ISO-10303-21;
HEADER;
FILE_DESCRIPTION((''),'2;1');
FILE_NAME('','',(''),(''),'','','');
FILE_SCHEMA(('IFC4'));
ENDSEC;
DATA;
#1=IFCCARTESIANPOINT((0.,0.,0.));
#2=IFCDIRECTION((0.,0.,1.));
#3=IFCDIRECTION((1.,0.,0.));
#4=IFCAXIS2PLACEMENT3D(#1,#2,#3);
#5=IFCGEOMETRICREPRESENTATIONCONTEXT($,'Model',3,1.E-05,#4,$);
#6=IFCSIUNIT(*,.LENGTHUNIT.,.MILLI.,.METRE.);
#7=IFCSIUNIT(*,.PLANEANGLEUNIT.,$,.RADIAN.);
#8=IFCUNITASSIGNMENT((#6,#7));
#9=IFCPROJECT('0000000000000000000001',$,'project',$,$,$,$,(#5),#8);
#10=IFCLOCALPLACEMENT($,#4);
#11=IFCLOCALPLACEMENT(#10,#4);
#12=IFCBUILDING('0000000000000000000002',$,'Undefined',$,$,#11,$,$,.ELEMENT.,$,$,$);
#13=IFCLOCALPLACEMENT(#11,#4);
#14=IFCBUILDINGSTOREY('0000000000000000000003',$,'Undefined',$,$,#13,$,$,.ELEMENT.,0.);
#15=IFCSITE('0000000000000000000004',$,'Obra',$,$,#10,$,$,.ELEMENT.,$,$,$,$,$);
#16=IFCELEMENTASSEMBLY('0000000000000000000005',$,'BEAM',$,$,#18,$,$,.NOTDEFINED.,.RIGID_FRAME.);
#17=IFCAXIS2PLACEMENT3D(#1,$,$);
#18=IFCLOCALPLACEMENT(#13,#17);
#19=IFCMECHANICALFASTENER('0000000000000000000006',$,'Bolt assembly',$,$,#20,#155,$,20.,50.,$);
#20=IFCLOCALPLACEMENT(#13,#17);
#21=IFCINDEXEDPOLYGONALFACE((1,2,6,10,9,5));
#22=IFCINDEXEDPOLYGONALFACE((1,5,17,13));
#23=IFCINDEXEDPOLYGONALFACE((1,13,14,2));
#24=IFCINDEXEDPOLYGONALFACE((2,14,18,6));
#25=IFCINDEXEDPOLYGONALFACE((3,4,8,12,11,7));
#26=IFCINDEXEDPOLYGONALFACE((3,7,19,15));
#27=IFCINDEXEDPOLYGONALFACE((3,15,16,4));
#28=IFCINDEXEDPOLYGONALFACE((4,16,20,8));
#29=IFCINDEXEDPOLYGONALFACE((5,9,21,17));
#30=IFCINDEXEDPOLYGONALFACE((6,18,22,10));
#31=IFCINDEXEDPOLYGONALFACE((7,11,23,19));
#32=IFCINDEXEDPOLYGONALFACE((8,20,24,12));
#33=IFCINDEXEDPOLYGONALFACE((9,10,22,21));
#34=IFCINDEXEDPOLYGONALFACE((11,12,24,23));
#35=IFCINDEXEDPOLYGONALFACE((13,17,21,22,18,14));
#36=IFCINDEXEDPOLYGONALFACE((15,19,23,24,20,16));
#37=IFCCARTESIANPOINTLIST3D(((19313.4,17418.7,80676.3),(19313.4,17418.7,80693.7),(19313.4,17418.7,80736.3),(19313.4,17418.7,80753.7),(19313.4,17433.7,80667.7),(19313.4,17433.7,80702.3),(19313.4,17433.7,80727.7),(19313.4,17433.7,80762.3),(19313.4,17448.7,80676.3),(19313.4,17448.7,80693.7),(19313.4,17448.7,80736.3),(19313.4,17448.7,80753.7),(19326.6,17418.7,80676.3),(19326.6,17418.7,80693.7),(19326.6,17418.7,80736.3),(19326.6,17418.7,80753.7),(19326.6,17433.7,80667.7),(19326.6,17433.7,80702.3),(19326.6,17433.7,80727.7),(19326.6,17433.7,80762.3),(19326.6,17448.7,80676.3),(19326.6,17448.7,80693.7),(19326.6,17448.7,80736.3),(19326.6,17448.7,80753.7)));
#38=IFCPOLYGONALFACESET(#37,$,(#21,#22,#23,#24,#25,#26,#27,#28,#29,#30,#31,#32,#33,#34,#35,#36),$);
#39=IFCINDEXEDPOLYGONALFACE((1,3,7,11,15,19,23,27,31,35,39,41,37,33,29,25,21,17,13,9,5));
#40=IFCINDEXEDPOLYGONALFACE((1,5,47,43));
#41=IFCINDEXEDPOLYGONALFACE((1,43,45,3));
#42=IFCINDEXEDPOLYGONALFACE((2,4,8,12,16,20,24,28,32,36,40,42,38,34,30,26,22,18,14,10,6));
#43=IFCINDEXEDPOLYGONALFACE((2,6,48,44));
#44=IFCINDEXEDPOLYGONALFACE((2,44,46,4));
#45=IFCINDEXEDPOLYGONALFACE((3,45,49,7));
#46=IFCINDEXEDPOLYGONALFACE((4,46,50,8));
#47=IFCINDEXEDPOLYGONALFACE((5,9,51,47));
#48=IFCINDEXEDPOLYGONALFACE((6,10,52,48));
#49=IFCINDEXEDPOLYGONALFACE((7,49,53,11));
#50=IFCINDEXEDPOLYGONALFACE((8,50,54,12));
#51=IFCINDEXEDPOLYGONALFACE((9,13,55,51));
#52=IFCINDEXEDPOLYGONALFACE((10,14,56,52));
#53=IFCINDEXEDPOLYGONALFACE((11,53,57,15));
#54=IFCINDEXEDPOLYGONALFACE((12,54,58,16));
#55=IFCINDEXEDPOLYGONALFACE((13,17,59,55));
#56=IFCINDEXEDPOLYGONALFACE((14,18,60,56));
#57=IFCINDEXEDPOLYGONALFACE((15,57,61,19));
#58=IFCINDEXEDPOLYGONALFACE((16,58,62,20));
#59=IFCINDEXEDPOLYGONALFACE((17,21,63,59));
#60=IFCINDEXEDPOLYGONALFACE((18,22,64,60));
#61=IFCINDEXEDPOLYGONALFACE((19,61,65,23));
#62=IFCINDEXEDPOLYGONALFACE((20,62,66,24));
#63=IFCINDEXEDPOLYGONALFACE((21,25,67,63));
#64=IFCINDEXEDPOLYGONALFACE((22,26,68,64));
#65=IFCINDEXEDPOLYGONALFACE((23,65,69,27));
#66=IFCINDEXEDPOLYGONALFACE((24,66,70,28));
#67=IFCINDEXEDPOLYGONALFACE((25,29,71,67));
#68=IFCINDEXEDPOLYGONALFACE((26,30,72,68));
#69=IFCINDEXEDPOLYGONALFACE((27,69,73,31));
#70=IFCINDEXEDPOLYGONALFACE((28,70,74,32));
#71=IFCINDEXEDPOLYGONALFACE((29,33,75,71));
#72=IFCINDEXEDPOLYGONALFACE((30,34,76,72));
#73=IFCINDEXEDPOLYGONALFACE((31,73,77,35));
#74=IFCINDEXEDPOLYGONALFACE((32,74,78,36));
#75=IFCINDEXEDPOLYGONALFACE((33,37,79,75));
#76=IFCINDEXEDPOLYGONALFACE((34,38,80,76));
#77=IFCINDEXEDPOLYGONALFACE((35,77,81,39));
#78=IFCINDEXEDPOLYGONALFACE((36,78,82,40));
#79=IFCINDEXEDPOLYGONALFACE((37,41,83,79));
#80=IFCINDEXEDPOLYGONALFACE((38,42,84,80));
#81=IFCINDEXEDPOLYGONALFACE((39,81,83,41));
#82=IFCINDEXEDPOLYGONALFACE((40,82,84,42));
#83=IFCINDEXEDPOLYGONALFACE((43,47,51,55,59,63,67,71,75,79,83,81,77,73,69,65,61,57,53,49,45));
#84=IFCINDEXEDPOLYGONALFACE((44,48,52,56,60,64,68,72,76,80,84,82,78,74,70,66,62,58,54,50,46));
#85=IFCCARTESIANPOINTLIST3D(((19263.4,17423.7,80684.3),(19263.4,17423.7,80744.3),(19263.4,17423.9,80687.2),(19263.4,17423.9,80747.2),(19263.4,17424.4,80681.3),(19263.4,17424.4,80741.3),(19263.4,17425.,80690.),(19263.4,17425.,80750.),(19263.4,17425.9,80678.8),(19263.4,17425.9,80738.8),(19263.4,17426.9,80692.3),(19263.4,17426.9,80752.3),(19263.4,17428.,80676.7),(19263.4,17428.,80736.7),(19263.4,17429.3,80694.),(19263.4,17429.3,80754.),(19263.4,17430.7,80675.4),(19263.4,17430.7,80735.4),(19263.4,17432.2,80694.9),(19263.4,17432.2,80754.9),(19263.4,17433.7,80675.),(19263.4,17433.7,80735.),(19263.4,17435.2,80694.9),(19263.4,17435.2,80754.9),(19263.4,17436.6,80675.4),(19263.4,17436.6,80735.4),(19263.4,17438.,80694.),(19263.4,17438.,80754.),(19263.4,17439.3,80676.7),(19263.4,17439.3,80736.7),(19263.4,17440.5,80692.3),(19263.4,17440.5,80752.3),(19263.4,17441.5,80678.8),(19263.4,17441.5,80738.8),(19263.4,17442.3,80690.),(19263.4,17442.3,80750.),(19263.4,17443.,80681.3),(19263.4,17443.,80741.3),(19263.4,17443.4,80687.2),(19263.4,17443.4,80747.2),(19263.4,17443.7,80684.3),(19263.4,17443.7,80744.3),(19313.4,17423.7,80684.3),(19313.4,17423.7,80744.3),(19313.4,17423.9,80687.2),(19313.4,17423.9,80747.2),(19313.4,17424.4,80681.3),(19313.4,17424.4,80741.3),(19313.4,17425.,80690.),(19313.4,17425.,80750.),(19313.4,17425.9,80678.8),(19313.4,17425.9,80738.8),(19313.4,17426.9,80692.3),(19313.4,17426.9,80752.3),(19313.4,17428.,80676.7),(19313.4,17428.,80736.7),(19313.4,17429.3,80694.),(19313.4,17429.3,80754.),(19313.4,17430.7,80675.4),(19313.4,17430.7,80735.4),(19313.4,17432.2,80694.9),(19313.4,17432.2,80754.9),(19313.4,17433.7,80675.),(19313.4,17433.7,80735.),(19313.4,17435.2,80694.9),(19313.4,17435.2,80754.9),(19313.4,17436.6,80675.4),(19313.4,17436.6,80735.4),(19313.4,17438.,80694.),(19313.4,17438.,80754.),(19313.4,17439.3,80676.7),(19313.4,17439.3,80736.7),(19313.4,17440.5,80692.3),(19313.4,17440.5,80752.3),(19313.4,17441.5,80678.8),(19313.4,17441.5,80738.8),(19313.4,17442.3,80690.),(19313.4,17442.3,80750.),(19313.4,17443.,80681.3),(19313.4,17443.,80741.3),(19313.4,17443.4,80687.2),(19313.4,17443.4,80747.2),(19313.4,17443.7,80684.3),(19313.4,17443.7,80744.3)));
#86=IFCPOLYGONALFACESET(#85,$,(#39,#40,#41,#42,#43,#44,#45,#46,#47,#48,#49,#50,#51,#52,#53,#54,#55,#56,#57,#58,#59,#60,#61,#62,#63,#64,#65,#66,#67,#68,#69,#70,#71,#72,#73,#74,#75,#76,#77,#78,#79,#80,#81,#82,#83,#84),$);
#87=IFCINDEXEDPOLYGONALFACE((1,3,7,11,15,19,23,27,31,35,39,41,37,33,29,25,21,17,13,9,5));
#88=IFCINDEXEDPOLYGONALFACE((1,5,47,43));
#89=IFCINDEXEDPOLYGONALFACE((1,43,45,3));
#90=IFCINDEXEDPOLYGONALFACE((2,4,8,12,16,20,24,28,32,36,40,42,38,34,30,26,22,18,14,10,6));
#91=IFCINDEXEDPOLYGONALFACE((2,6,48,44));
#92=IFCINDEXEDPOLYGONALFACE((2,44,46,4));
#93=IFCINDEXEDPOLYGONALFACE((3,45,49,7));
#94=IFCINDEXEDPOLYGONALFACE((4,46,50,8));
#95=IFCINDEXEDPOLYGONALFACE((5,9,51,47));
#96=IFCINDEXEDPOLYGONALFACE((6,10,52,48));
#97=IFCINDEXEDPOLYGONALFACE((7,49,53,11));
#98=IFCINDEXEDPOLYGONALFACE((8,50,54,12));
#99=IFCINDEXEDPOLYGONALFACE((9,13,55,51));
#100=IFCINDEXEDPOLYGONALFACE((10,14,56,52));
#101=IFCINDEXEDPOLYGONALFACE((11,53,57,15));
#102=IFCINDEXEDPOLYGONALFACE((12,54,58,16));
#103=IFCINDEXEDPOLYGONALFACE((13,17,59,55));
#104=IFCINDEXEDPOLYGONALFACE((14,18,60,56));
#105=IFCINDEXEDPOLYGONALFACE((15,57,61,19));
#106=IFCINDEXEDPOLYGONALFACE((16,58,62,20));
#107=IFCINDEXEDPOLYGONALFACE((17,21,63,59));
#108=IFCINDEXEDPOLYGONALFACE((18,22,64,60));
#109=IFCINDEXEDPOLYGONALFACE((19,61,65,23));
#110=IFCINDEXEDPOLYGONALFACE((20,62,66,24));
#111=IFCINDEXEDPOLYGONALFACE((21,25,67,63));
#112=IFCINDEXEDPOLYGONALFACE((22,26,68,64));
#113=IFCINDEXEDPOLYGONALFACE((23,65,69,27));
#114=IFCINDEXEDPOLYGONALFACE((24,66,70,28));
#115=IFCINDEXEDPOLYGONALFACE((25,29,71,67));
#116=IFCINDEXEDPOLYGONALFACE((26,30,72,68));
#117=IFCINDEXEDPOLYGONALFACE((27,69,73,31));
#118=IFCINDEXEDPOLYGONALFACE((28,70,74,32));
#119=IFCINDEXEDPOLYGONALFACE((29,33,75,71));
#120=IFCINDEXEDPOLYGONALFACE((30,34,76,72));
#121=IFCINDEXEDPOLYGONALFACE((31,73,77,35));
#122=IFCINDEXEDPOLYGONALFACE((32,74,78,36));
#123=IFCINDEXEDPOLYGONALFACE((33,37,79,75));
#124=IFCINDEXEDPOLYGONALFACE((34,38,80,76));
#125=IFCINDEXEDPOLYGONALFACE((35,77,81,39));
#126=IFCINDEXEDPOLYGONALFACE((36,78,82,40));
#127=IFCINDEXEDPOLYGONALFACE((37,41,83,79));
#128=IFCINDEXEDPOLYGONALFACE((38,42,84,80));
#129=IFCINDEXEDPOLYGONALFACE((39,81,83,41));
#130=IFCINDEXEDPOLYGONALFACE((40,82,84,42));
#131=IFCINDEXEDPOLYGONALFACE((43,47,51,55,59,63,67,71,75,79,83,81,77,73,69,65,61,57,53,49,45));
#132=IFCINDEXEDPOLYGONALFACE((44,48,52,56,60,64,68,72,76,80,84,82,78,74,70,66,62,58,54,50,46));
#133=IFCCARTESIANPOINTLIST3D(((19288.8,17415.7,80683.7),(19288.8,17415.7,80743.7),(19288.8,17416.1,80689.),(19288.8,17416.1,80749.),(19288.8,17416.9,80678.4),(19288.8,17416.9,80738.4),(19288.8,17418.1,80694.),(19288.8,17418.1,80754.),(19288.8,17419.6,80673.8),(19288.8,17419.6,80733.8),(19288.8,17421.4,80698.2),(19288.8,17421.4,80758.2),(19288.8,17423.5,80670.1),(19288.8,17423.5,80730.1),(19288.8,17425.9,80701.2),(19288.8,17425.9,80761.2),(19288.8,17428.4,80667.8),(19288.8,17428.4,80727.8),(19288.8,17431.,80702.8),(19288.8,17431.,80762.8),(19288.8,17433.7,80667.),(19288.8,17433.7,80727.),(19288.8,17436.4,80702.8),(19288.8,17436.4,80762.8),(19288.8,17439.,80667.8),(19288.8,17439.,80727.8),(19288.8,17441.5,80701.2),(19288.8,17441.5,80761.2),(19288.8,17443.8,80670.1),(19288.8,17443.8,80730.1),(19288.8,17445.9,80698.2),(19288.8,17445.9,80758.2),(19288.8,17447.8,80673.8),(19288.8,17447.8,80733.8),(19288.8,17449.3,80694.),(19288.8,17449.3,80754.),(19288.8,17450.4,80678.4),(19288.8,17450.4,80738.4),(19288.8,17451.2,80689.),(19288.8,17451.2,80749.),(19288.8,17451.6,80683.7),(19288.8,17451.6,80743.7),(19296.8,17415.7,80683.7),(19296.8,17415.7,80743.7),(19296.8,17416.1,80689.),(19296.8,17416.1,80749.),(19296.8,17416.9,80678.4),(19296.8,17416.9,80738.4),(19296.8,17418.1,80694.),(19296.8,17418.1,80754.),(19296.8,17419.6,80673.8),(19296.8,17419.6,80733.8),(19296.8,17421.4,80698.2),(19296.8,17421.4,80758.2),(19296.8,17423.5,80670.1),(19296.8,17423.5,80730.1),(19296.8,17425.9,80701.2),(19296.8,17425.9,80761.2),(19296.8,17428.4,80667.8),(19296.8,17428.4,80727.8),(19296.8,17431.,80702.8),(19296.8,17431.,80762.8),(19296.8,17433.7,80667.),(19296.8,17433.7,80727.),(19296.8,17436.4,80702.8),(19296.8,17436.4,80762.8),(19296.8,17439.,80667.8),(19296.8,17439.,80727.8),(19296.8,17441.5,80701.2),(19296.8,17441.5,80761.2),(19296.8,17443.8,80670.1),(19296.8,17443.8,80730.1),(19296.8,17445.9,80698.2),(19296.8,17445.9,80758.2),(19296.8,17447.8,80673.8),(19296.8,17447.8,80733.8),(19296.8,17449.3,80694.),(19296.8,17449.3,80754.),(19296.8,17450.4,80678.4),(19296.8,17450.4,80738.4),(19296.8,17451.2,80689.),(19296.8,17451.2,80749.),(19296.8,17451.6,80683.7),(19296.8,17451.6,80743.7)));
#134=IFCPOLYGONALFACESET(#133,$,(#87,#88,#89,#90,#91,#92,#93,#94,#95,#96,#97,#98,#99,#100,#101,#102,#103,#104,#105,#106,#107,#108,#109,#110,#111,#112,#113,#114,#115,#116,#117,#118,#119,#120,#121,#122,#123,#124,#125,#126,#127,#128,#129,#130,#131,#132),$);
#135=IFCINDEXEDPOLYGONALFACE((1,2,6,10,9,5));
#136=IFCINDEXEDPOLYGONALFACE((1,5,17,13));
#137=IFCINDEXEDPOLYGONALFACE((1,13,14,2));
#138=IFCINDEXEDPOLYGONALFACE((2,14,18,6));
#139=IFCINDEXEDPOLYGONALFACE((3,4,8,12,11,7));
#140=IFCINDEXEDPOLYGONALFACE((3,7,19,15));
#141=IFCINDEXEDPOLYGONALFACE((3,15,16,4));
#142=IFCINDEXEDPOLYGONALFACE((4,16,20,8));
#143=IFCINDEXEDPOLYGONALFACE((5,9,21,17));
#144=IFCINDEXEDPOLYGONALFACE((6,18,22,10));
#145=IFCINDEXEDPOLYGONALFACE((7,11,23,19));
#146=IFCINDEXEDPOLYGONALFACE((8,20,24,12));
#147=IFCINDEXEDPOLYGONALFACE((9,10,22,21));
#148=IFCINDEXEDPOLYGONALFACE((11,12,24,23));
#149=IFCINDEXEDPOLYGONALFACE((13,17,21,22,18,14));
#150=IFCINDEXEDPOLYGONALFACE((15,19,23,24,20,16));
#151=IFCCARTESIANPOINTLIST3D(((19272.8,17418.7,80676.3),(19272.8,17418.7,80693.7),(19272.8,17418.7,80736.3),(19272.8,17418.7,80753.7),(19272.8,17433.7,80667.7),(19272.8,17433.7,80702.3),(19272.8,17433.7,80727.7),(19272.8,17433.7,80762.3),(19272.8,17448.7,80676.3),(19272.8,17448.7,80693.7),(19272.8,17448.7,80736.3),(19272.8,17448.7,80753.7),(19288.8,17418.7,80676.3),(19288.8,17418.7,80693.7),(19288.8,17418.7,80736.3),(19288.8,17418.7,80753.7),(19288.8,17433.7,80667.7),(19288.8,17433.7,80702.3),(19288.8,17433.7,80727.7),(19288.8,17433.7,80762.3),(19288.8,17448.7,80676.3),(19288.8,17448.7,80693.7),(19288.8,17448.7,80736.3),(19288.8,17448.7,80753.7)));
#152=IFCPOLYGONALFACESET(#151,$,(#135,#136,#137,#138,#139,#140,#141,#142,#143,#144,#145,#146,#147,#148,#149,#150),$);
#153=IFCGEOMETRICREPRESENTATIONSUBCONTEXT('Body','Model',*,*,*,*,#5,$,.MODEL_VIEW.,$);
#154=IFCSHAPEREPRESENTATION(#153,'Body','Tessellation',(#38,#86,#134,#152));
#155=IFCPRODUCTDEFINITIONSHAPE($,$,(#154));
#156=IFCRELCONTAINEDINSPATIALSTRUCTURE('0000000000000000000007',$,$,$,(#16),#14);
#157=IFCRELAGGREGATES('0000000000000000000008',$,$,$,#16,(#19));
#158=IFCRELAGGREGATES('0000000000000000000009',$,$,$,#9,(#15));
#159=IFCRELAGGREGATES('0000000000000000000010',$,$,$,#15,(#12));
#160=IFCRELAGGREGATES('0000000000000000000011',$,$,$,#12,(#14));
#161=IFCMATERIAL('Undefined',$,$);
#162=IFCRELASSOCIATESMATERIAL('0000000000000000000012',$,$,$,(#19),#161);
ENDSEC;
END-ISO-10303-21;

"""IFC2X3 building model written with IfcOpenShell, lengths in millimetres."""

from ifc_helpers import new_model, si_unit, frame, origin_with_axes, origin_2d_with_axis, place, context, subcontext, project, spatial, polyline, circle, outline, extrude, source, transform, mapped, material, element, aggregate, save


model = new_model("IFC2X3")

# Units and contexts
model_context = context("Model", 3, precision=1e-05, world=origin_with_axes())
body_context = subcontext(model_context, "Body", "Model", "MODEL_VIEW")
ifc_project = project(units=[si_unit("LENGTHUNIT", "METRE", prefix="MILLI"), si_unit("PLANEANGLEUNIT", "RADIAN")], contexts=[model_context])

# Site, building, storey
site_placement = place(None, origin_with_axes())
site = spatial("IfcSite", under=ifc_project, at=site_placement, Name="Obra", CompositionType="ELEMENT")
building_placement = place(site_placement, origin_with_axes())
building = spatial("IfcBuilding", under=site, at=building_placement, Name="Undefined", CompositionType="ELEMENT")
storey_placement = place(building_placement, origin_with_axes())
storey = spatial("IfcBuildingStorey", under=building, at=storey_placement, Name="Undefined", CompositionType="ELEMENT", Elevation=0.0)

# Element assembly
assembly_1_placement = place(storey_placement, origin_with_axes())
assembly_1 = element("IfcElementAssembly", 1, at=assembly_1_placement, inside=storey, Name="BEAM", AssemblyPlace="NOTDEFINED", PredefinedType="RIGID_FRAME")
ifc_material_1 = material(Name="Undefined")
shared_shape_1 = source(origin_with_axes(), body_context, "Body", "SweptSolid", [
    extrude(outline(polyline([(17.3, 0.0), (8.7, 15.0), (-8.7, 15.0), (-17.3, 0.0), (-8.7, -15.0), (8.7, -15.0), (17.3, 0.0)])), frame((0.0, -26.5, 0.0), z_axis=(0.0, 1.0, 0.0), x_axis=(1.0, 0.0, 0.0)), (0.0, 0.0, 1.0), 13.2),
    extrude(circle(Radius=10.0, at=origin_2d_with_axis()), frame((0.0, -13.3, 0.0), z_axis=(0.0, 1.0, 0.0), x_axis=(1.0, 0.0, 0.0)), (0.0, 0.0, 1.0), 50.0),
    extrude(circle(Radius=18.0, at=origin_2d_with_axis()), frame((0.0, 3.3, 0.0), z_axis=(0.0, 1.0, 0.0), x_axis=(1.0, 0.0, 0.0)), (0.0, 0.0, 1.0), 8.0),
    extrude(outline(polyline([(17.3, 0.0), (8.7, 15.0), (-8.7, 15.0), (-17.3, 0.0), (-8.7, -15.0), (8.7, -15.0), (17.3, 0.0)])), frame((0.0, 11.3, 0.0), z_axis=(0.0, 1.0, 0.0), x_axis=(1.0, 0.0, 0.0)), (0.0, 0.0, 1.0), 16.0),
])

# Mechanical fastener
mechanical_fastener_1_placement = place(assembly_1_placement, frame((19300.1, 17393.7, 80850.0), z_axis=(0.0, 1.0, 0.0), x_axis=(0.0, 0.0, -1.0)))
mechanical_fastener_1 = element("IfcMechanicalFastener", 2, at=mechanical_fastener_1_placement, material=ifc_material_1, Name="Bolt assembly", NominalDiameter=20.0, NominalLength=50.0, context=body_context, shape_type="MappedRepresentation", body=[
    mapped(shared_shape_1, transform((105.0, 0.0, 40.0))),
    mapped(shared_shape_1, transform((165.0, 0.0, 40.0))),
])
aggregate(assembly_1, [mechanical_fastener_1])

save(model, "model.ifc")
